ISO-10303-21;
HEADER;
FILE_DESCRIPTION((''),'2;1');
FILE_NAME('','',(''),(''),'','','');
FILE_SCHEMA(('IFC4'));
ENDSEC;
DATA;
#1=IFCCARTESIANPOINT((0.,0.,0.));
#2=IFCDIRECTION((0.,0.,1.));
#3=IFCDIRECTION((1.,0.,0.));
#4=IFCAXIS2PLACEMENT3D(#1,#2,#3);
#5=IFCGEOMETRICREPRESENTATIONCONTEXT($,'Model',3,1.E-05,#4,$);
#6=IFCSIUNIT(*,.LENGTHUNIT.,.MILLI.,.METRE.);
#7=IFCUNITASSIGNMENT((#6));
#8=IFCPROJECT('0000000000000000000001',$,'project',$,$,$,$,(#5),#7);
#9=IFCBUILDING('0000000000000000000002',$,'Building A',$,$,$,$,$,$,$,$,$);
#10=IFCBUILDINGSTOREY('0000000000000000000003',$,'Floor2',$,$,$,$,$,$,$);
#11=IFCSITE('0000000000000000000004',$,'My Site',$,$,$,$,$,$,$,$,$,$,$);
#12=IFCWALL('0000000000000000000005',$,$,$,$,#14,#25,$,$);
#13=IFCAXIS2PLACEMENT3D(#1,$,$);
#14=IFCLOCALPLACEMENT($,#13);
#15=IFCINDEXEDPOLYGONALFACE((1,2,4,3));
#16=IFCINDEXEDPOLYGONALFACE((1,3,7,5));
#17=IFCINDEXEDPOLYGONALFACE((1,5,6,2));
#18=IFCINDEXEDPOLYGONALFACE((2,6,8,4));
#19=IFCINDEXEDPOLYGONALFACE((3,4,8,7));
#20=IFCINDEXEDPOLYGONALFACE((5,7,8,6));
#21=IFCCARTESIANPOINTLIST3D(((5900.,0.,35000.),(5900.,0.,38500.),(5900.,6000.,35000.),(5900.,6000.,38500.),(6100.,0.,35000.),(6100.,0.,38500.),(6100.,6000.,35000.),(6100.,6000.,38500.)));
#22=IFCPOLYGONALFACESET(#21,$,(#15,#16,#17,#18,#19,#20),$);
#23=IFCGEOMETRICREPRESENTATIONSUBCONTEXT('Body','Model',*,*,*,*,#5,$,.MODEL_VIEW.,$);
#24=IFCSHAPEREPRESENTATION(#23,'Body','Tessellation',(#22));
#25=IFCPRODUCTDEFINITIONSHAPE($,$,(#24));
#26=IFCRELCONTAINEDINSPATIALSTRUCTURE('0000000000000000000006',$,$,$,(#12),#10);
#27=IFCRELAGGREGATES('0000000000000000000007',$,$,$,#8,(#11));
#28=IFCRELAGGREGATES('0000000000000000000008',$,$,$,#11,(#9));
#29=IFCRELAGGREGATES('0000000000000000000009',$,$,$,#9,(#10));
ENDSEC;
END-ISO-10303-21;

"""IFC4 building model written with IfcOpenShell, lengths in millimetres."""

from ifc_helpers import new_model, si_unit, frame, origin_with_axes, place, context, subcontext, project, spatial, indexed_curve, outline, extrude, element, save


model = new_model("IFC4")

# Units and contexts
model_context = context("Model", 3, precision=1e-05, world=origin_with_axes())
body_context = subcontext(model_context, "Body", "Model", "MODEL_VIEW")
ifc_project = project(units=[si_unit("LENGTHUNIT", "METRE", prefix="MILLI")], contexts=[model_context])

# Site, building, storey
site = spatial("IfcSite", under=ifc_project, Name="My Site")
building = spatial("IfcBuilding", under=site, Name="Building A")
storey = spatial("IfcBuildingStorey", under=building, Name="Floor2")

# Wall
wall_placement = place(None, frame((6100.0, 0.0, 35000.0), z_axis=(0.0, 0.0, 1.0), x_axis=(0.0, 1.0, 0.0)))
element("IfcWall", 1, at=wall_placement, inside=storey, context=body_context, shape_type="SweptSolid", body=[
    extrude(outline(indexed_curve([(0.0, 0.0), (0.0, 200.0), (6000.0, 200.0), (6000.0, 0.0), (0.0, 0.0)], self_intersect=False)), origin_with_axes(), (0.0, 0.0, 1.0), 3500.0),
])

save(model, "model.ifc")
